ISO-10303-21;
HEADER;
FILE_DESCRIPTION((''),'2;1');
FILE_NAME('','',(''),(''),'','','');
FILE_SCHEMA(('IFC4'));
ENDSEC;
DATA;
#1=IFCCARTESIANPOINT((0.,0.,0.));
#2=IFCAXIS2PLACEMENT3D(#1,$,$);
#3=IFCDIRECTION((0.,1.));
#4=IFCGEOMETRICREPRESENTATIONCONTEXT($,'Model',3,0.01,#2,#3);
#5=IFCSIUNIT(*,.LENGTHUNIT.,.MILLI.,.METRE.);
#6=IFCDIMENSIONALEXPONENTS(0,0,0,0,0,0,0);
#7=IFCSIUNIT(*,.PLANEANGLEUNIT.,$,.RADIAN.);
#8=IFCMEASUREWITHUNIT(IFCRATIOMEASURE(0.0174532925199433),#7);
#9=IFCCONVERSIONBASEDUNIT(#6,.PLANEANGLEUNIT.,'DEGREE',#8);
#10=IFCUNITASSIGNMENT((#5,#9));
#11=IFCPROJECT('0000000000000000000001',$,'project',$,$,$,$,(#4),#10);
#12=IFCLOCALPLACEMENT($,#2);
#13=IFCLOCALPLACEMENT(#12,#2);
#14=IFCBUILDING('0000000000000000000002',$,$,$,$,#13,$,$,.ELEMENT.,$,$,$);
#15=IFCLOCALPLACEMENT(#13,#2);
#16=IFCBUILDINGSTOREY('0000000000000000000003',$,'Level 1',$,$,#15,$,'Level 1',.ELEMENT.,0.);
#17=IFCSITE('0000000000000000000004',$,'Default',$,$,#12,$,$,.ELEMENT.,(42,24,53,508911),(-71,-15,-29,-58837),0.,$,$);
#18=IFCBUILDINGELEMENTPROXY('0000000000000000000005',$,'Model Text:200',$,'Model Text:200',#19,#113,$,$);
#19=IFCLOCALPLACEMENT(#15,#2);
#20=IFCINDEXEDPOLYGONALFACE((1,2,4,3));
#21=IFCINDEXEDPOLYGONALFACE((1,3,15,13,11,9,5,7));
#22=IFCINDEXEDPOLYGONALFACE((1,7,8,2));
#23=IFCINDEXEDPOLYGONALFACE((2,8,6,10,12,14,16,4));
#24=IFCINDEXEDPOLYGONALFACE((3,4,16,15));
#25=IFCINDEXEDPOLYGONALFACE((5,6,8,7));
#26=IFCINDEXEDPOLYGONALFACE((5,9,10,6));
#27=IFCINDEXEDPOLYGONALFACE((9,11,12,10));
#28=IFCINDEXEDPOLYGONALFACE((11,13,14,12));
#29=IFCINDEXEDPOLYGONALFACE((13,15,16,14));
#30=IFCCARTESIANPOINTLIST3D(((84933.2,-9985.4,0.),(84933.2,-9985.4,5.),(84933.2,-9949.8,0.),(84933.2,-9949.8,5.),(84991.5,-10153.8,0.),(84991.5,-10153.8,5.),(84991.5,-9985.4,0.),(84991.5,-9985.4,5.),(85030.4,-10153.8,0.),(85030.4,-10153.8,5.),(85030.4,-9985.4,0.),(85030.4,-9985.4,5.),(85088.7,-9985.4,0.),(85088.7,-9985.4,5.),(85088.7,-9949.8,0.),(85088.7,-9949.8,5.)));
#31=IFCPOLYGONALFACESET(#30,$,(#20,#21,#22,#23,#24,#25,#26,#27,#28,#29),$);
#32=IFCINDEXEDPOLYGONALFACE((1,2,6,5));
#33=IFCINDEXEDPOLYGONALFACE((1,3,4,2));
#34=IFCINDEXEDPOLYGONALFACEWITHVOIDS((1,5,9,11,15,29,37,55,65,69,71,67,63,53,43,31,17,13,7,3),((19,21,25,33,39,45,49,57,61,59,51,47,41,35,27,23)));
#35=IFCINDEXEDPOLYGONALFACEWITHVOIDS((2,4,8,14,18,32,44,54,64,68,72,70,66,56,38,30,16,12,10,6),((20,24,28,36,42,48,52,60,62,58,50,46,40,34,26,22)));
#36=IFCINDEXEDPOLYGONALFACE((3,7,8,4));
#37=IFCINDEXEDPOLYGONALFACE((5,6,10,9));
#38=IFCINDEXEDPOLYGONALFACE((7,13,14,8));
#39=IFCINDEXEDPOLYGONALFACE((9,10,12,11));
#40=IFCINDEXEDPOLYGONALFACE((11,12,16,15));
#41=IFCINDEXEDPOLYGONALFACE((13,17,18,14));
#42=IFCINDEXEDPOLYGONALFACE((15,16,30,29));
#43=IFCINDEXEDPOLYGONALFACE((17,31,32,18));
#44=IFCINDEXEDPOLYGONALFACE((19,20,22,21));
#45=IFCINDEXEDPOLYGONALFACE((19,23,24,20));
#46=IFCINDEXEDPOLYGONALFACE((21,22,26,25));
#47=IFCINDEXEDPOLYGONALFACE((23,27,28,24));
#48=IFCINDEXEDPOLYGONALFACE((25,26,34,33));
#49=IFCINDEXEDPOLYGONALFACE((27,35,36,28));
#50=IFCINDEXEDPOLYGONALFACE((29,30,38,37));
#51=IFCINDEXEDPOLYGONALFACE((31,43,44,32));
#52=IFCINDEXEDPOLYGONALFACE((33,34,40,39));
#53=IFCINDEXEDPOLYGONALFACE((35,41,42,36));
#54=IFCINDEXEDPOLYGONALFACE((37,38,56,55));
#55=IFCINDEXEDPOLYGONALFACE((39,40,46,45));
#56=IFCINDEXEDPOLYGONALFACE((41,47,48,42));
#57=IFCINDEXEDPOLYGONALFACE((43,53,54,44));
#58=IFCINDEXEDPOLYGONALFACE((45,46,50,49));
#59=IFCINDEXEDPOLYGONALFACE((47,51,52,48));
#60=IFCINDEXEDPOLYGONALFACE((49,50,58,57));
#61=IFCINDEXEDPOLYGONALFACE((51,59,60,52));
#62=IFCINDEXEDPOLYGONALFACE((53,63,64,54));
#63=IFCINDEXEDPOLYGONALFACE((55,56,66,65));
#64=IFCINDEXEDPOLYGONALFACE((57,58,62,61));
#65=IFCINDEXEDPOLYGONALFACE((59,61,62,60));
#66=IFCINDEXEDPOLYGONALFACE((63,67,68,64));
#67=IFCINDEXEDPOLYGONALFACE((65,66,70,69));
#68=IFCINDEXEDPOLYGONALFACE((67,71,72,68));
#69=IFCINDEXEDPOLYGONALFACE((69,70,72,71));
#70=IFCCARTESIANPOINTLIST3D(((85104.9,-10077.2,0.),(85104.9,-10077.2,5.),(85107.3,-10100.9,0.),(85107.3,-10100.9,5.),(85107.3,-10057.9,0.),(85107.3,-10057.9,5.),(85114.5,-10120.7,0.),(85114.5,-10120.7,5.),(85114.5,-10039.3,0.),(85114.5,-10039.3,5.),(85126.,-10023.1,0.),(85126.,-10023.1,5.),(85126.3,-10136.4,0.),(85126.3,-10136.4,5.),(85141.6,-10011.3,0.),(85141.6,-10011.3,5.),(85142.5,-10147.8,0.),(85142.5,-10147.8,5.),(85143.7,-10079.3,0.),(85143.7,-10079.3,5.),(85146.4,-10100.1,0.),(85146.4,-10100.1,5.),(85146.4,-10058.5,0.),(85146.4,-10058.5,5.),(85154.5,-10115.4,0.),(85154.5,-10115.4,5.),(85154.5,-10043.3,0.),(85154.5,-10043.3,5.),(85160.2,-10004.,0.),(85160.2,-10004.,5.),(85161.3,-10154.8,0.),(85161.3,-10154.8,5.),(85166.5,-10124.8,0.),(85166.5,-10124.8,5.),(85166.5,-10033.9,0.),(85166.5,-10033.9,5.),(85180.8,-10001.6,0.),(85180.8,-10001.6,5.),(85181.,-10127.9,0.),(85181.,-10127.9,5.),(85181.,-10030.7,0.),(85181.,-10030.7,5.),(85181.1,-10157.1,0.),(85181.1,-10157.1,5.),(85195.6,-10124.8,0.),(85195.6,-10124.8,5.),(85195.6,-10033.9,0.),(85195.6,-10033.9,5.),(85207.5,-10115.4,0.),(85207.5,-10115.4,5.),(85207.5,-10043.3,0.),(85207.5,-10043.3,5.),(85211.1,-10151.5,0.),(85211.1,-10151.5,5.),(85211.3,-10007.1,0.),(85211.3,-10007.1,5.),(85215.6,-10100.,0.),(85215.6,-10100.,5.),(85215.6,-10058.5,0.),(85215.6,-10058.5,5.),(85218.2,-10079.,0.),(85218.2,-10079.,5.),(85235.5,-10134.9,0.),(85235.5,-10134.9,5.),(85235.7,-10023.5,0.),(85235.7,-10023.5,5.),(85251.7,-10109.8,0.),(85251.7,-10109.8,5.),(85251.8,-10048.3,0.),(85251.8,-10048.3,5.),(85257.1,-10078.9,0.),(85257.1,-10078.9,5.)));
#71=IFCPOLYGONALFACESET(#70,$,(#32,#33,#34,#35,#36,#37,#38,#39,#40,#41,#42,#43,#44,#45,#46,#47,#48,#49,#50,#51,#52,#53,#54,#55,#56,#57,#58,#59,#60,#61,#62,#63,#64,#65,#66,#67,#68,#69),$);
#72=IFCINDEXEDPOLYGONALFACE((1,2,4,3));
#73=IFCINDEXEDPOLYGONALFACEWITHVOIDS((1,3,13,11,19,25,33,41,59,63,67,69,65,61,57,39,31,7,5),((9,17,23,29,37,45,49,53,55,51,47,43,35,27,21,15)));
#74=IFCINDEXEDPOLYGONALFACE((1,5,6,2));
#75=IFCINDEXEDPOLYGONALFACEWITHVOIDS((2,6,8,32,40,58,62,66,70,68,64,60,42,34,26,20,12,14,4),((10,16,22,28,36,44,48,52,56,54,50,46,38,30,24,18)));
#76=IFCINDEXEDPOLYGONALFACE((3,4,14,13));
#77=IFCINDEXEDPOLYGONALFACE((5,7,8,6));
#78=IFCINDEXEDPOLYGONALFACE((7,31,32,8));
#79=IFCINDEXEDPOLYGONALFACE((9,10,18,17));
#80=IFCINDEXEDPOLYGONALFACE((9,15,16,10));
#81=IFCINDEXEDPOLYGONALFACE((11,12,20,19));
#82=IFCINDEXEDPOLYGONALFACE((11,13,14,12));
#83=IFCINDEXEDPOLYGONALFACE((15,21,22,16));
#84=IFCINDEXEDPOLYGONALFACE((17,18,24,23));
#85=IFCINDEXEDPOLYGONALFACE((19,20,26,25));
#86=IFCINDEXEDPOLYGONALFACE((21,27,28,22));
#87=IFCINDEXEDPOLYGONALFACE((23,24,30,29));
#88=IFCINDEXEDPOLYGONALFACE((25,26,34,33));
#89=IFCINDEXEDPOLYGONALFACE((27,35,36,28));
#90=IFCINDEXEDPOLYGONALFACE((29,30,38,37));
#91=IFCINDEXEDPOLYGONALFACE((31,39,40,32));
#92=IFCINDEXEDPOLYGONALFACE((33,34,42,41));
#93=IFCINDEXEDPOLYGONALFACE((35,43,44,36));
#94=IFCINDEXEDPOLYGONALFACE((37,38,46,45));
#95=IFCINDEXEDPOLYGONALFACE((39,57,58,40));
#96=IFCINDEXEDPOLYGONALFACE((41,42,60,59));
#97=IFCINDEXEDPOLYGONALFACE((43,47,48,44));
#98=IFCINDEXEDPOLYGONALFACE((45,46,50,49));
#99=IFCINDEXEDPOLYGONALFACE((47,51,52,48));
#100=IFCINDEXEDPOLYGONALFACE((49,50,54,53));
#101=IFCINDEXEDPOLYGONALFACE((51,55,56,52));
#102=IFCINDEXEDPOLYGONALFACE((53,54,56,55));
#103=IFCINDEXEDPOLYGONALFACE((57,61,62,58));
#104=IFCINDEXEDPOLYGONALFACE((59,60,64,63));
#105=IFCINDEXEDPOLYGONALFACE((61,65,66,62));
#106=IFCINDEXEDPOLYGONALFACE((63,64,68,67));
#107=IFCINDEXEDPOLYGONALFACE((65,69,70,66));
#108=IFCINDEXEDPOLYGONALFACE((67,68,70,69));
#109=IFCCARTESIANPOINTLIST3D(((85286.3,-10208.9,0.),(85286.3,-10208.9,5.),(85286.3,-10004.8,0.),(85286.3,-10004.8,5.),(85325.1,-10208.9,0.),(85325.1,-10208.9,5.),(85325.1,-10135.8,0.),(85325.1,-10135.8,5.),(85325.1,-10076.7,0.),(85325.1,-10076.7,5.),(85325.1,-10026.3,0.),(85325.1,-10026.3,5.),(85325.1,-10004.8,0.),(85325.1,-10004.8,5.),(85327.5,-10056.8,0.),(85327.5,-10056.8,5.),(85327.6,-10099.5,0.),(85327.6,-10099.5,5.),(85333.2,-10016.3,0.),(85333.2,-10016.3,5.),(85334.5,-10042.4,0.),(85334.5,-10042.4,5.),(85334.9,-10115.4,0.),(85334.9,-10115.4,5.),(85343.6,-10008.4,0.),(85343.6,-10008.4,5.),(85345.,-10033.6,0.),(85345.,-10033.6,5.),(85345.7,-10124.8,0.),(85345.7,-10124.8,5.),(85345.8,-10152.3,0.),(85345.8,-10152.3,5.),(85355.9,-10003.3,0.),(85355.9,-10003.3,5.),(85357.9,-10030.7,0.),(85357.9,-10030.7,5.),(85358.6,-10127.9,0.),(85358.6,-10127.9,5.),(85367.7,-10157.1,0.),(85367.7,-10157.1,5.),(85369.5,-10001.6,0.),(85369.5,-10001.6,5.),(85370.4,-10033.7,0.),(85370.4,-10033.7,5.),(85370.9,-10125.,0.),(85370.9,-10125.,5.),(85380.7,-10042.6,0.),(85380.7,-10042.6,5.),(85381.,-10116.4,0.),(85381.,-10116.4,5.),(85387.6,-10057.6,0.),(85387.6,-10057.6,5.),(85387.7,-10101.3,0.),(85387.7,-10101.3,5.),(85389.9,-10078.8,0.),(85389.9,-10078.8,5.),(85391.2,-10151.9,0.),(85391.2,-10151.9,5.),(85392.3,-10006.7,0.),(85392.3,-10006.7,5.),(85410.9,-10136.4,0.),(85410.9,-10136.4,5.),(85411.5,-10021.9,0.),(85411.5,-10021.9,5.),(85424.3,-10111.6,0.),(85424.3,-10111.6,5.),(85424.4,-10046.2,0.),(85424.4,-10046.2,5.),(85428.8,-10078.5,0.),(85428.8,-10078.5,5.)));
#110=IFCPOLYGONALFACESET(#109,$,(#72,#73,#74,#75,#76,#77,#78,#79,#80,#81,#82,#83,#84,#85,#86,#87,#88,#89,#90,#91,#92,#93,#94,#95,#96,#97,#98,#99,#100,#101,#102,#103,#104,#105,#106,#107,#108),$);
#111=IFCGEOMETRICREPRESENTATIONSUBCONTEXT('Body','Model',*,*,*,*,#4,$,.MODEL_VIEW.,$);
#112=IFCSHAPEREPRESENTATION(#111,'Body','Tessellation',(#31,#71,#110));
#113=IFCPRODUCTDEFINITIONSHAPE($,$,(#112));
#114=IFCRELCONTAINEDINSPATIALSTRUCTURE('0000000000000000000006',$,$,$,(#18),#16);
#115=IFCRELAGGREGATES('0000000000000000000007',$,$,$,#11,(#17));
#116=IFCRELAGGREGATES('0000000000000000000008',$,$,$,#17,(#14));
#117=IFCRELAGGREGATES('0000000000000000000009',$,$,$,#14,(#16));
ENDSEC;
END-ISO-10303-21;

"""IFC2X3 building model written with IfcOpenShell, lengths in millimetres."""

from ifc_helpers import new_model, entity, si_unit, converted_unit, direction, frame, origin, place, context, subcontext, project, spatial, polyline, outline, extrude, element, save


model = new_model("IFC2X3")

# Units and contexts
model_context = context("Model", 3, precision=0.01, world=origin(), true_north=direction((0.0, 1.0)))
body_context = subcontext(model_context, "Body", "Model", "MODEL_VIEW")
ifc_project = project(units=[si_unit("LENGTHUNIT", "METRE", prefix="MILLI"), converted_unit("PLANEANGLEUNIT", "DEGREE", entity("IfcRatioMeasure", 0.0174532925199433), si_unit("PLANEANGLEUNIT", "RADIAN"), dimensions=[0, 0, 0, 0, 0, 0, 0])], contexts=[model_context])

# Site, building, storey
site_placement = place(None, origin())
site = spatial("IfcSite", under=ifc_project, at=site_placement, Name="Default", CompositionType="ELEMENT", RefLatitude=(42, 24, 53, 508911), RefLongitude=(-71, -15, -29, -58837), RefElevation=0.0)
building_placement = place(site_placement, origin())
building = spatial("IfcBuilding", under=site, at=building_placement, CompositionType="ELEMENT")
storey_placement = place(building_placement, origin())
storey = spatial("IfcBuildingStorey", under=building, at=storey_placement, Name="Level 1", LongName="Level 1", CompositionType="ELEMENT", Elevation=0.0)

# Building element proxy
proxy_1_placement = place(storey_placement, origin())
element("IfcBuildingElementProxy", 1, at=proxy_1_placement, inside=storey, Name="Model Text:200", ObjectType="Model Text:200", context=body_context, shape_type="SweptSolid", body=[
    extrude(outline(polyline([(-19.4, -135.2), (19.4, -135.2), (19.4, 33.2), (77.7, 33.2), (77.7, 68.8), (-77.7, 68.8), (-77.7, 33.2), (-19.4, 33.2), (-19.4, -135.2)])), frame((85010.9, -10018.6, 0.0)), (0.0, 0.0, 1.0), 5.0),
    extrude(outline(polyline([(-8.8, -65.7), (15.1, -65.7), (35.5, -60.5), (52.3, -50.4), (65.3, -35.4), (74.1, -17.3), (78.4, 2.1), (75.9, 32.5), (61.8, 58.5), (38.4, 77.1), (8.3, 85.6), (-22.7, 83.3), (-49.0, 69.9), (-67.8, 47.3), (-76.3, 17.5), (-76.0, -3.3), (-70.7, -22.5), (-60.5, -39.2), (-45.5, -52.3), (-27.7, -61.4), (-8.8, -65.7)]), holes=[polyline([(-2.7, -27.2), (-23.1, -22.5), (-37.5, -12.9), (-45.7, 0.0), (-47.3, 14.8), (-42.7, 28.9), (-32.2, 39.9), (-16.3, 46.3), (4.5, 46.9), (25.1, 42.1), (39.6, 32.6), (47.7, 19.7), (49.4, 5.0), (44.8, -9.2), (34.2, -20.2), (18.2, -26.7), (-2.7, -27.2)])]), frame((85171.1, -10079.3, 0.0), z_axis=(0.0, 0.0, 1.0), x_axis=(0.100608, -0.994926, 0.0)), (0.0, 0.0, 1.0), 5.0),
    extrude(outline(polyline([(-73.1, -75.4), (130.9, -75.4), (130.9, -36.6), (57.8, -36.6), (74.3, -15.9), (79.1, 6.0), (73.9, 29.5), (58.4, 49.2), (33.6, 62.6), (0.5, 67.1), (-31.8, 62.8), (-56.1, 49.8), (-71.3, 30.7), (-76.4, 7.8), (-74.7, -5.8), (-69.6, -18.1), (-61.7, -28.5), (-51.7, -36.6), (-73.1, -36.6), (-73.1, -75.4)]), holes=[polyline([(-1.2, -36.6), (-21.2, -34.2), (-35.6, -27.2), (-44.3, -16.7), (-47.2, -3.8), (-44.3, 8.7), (-35.4, 19.0), (-20.4, 25.9), (0.8, 28.2), (23.3, 26.0), (38.5, 19.3), (47.1, 9.2), (49.9, -3.1), (46.8, -16.0), (37.4, -26.8), (21.5, -34.1), (-1.2, -36.6)])]), frame((85361.7, -10078.0, 0.0), z_axis=(0.0, 0.0, 1.0), x_axis=(0.0, -1.0, 0.0)), (0.0, 0.0, 1.0), 5.0),
])

save(model, "model.ifc")
